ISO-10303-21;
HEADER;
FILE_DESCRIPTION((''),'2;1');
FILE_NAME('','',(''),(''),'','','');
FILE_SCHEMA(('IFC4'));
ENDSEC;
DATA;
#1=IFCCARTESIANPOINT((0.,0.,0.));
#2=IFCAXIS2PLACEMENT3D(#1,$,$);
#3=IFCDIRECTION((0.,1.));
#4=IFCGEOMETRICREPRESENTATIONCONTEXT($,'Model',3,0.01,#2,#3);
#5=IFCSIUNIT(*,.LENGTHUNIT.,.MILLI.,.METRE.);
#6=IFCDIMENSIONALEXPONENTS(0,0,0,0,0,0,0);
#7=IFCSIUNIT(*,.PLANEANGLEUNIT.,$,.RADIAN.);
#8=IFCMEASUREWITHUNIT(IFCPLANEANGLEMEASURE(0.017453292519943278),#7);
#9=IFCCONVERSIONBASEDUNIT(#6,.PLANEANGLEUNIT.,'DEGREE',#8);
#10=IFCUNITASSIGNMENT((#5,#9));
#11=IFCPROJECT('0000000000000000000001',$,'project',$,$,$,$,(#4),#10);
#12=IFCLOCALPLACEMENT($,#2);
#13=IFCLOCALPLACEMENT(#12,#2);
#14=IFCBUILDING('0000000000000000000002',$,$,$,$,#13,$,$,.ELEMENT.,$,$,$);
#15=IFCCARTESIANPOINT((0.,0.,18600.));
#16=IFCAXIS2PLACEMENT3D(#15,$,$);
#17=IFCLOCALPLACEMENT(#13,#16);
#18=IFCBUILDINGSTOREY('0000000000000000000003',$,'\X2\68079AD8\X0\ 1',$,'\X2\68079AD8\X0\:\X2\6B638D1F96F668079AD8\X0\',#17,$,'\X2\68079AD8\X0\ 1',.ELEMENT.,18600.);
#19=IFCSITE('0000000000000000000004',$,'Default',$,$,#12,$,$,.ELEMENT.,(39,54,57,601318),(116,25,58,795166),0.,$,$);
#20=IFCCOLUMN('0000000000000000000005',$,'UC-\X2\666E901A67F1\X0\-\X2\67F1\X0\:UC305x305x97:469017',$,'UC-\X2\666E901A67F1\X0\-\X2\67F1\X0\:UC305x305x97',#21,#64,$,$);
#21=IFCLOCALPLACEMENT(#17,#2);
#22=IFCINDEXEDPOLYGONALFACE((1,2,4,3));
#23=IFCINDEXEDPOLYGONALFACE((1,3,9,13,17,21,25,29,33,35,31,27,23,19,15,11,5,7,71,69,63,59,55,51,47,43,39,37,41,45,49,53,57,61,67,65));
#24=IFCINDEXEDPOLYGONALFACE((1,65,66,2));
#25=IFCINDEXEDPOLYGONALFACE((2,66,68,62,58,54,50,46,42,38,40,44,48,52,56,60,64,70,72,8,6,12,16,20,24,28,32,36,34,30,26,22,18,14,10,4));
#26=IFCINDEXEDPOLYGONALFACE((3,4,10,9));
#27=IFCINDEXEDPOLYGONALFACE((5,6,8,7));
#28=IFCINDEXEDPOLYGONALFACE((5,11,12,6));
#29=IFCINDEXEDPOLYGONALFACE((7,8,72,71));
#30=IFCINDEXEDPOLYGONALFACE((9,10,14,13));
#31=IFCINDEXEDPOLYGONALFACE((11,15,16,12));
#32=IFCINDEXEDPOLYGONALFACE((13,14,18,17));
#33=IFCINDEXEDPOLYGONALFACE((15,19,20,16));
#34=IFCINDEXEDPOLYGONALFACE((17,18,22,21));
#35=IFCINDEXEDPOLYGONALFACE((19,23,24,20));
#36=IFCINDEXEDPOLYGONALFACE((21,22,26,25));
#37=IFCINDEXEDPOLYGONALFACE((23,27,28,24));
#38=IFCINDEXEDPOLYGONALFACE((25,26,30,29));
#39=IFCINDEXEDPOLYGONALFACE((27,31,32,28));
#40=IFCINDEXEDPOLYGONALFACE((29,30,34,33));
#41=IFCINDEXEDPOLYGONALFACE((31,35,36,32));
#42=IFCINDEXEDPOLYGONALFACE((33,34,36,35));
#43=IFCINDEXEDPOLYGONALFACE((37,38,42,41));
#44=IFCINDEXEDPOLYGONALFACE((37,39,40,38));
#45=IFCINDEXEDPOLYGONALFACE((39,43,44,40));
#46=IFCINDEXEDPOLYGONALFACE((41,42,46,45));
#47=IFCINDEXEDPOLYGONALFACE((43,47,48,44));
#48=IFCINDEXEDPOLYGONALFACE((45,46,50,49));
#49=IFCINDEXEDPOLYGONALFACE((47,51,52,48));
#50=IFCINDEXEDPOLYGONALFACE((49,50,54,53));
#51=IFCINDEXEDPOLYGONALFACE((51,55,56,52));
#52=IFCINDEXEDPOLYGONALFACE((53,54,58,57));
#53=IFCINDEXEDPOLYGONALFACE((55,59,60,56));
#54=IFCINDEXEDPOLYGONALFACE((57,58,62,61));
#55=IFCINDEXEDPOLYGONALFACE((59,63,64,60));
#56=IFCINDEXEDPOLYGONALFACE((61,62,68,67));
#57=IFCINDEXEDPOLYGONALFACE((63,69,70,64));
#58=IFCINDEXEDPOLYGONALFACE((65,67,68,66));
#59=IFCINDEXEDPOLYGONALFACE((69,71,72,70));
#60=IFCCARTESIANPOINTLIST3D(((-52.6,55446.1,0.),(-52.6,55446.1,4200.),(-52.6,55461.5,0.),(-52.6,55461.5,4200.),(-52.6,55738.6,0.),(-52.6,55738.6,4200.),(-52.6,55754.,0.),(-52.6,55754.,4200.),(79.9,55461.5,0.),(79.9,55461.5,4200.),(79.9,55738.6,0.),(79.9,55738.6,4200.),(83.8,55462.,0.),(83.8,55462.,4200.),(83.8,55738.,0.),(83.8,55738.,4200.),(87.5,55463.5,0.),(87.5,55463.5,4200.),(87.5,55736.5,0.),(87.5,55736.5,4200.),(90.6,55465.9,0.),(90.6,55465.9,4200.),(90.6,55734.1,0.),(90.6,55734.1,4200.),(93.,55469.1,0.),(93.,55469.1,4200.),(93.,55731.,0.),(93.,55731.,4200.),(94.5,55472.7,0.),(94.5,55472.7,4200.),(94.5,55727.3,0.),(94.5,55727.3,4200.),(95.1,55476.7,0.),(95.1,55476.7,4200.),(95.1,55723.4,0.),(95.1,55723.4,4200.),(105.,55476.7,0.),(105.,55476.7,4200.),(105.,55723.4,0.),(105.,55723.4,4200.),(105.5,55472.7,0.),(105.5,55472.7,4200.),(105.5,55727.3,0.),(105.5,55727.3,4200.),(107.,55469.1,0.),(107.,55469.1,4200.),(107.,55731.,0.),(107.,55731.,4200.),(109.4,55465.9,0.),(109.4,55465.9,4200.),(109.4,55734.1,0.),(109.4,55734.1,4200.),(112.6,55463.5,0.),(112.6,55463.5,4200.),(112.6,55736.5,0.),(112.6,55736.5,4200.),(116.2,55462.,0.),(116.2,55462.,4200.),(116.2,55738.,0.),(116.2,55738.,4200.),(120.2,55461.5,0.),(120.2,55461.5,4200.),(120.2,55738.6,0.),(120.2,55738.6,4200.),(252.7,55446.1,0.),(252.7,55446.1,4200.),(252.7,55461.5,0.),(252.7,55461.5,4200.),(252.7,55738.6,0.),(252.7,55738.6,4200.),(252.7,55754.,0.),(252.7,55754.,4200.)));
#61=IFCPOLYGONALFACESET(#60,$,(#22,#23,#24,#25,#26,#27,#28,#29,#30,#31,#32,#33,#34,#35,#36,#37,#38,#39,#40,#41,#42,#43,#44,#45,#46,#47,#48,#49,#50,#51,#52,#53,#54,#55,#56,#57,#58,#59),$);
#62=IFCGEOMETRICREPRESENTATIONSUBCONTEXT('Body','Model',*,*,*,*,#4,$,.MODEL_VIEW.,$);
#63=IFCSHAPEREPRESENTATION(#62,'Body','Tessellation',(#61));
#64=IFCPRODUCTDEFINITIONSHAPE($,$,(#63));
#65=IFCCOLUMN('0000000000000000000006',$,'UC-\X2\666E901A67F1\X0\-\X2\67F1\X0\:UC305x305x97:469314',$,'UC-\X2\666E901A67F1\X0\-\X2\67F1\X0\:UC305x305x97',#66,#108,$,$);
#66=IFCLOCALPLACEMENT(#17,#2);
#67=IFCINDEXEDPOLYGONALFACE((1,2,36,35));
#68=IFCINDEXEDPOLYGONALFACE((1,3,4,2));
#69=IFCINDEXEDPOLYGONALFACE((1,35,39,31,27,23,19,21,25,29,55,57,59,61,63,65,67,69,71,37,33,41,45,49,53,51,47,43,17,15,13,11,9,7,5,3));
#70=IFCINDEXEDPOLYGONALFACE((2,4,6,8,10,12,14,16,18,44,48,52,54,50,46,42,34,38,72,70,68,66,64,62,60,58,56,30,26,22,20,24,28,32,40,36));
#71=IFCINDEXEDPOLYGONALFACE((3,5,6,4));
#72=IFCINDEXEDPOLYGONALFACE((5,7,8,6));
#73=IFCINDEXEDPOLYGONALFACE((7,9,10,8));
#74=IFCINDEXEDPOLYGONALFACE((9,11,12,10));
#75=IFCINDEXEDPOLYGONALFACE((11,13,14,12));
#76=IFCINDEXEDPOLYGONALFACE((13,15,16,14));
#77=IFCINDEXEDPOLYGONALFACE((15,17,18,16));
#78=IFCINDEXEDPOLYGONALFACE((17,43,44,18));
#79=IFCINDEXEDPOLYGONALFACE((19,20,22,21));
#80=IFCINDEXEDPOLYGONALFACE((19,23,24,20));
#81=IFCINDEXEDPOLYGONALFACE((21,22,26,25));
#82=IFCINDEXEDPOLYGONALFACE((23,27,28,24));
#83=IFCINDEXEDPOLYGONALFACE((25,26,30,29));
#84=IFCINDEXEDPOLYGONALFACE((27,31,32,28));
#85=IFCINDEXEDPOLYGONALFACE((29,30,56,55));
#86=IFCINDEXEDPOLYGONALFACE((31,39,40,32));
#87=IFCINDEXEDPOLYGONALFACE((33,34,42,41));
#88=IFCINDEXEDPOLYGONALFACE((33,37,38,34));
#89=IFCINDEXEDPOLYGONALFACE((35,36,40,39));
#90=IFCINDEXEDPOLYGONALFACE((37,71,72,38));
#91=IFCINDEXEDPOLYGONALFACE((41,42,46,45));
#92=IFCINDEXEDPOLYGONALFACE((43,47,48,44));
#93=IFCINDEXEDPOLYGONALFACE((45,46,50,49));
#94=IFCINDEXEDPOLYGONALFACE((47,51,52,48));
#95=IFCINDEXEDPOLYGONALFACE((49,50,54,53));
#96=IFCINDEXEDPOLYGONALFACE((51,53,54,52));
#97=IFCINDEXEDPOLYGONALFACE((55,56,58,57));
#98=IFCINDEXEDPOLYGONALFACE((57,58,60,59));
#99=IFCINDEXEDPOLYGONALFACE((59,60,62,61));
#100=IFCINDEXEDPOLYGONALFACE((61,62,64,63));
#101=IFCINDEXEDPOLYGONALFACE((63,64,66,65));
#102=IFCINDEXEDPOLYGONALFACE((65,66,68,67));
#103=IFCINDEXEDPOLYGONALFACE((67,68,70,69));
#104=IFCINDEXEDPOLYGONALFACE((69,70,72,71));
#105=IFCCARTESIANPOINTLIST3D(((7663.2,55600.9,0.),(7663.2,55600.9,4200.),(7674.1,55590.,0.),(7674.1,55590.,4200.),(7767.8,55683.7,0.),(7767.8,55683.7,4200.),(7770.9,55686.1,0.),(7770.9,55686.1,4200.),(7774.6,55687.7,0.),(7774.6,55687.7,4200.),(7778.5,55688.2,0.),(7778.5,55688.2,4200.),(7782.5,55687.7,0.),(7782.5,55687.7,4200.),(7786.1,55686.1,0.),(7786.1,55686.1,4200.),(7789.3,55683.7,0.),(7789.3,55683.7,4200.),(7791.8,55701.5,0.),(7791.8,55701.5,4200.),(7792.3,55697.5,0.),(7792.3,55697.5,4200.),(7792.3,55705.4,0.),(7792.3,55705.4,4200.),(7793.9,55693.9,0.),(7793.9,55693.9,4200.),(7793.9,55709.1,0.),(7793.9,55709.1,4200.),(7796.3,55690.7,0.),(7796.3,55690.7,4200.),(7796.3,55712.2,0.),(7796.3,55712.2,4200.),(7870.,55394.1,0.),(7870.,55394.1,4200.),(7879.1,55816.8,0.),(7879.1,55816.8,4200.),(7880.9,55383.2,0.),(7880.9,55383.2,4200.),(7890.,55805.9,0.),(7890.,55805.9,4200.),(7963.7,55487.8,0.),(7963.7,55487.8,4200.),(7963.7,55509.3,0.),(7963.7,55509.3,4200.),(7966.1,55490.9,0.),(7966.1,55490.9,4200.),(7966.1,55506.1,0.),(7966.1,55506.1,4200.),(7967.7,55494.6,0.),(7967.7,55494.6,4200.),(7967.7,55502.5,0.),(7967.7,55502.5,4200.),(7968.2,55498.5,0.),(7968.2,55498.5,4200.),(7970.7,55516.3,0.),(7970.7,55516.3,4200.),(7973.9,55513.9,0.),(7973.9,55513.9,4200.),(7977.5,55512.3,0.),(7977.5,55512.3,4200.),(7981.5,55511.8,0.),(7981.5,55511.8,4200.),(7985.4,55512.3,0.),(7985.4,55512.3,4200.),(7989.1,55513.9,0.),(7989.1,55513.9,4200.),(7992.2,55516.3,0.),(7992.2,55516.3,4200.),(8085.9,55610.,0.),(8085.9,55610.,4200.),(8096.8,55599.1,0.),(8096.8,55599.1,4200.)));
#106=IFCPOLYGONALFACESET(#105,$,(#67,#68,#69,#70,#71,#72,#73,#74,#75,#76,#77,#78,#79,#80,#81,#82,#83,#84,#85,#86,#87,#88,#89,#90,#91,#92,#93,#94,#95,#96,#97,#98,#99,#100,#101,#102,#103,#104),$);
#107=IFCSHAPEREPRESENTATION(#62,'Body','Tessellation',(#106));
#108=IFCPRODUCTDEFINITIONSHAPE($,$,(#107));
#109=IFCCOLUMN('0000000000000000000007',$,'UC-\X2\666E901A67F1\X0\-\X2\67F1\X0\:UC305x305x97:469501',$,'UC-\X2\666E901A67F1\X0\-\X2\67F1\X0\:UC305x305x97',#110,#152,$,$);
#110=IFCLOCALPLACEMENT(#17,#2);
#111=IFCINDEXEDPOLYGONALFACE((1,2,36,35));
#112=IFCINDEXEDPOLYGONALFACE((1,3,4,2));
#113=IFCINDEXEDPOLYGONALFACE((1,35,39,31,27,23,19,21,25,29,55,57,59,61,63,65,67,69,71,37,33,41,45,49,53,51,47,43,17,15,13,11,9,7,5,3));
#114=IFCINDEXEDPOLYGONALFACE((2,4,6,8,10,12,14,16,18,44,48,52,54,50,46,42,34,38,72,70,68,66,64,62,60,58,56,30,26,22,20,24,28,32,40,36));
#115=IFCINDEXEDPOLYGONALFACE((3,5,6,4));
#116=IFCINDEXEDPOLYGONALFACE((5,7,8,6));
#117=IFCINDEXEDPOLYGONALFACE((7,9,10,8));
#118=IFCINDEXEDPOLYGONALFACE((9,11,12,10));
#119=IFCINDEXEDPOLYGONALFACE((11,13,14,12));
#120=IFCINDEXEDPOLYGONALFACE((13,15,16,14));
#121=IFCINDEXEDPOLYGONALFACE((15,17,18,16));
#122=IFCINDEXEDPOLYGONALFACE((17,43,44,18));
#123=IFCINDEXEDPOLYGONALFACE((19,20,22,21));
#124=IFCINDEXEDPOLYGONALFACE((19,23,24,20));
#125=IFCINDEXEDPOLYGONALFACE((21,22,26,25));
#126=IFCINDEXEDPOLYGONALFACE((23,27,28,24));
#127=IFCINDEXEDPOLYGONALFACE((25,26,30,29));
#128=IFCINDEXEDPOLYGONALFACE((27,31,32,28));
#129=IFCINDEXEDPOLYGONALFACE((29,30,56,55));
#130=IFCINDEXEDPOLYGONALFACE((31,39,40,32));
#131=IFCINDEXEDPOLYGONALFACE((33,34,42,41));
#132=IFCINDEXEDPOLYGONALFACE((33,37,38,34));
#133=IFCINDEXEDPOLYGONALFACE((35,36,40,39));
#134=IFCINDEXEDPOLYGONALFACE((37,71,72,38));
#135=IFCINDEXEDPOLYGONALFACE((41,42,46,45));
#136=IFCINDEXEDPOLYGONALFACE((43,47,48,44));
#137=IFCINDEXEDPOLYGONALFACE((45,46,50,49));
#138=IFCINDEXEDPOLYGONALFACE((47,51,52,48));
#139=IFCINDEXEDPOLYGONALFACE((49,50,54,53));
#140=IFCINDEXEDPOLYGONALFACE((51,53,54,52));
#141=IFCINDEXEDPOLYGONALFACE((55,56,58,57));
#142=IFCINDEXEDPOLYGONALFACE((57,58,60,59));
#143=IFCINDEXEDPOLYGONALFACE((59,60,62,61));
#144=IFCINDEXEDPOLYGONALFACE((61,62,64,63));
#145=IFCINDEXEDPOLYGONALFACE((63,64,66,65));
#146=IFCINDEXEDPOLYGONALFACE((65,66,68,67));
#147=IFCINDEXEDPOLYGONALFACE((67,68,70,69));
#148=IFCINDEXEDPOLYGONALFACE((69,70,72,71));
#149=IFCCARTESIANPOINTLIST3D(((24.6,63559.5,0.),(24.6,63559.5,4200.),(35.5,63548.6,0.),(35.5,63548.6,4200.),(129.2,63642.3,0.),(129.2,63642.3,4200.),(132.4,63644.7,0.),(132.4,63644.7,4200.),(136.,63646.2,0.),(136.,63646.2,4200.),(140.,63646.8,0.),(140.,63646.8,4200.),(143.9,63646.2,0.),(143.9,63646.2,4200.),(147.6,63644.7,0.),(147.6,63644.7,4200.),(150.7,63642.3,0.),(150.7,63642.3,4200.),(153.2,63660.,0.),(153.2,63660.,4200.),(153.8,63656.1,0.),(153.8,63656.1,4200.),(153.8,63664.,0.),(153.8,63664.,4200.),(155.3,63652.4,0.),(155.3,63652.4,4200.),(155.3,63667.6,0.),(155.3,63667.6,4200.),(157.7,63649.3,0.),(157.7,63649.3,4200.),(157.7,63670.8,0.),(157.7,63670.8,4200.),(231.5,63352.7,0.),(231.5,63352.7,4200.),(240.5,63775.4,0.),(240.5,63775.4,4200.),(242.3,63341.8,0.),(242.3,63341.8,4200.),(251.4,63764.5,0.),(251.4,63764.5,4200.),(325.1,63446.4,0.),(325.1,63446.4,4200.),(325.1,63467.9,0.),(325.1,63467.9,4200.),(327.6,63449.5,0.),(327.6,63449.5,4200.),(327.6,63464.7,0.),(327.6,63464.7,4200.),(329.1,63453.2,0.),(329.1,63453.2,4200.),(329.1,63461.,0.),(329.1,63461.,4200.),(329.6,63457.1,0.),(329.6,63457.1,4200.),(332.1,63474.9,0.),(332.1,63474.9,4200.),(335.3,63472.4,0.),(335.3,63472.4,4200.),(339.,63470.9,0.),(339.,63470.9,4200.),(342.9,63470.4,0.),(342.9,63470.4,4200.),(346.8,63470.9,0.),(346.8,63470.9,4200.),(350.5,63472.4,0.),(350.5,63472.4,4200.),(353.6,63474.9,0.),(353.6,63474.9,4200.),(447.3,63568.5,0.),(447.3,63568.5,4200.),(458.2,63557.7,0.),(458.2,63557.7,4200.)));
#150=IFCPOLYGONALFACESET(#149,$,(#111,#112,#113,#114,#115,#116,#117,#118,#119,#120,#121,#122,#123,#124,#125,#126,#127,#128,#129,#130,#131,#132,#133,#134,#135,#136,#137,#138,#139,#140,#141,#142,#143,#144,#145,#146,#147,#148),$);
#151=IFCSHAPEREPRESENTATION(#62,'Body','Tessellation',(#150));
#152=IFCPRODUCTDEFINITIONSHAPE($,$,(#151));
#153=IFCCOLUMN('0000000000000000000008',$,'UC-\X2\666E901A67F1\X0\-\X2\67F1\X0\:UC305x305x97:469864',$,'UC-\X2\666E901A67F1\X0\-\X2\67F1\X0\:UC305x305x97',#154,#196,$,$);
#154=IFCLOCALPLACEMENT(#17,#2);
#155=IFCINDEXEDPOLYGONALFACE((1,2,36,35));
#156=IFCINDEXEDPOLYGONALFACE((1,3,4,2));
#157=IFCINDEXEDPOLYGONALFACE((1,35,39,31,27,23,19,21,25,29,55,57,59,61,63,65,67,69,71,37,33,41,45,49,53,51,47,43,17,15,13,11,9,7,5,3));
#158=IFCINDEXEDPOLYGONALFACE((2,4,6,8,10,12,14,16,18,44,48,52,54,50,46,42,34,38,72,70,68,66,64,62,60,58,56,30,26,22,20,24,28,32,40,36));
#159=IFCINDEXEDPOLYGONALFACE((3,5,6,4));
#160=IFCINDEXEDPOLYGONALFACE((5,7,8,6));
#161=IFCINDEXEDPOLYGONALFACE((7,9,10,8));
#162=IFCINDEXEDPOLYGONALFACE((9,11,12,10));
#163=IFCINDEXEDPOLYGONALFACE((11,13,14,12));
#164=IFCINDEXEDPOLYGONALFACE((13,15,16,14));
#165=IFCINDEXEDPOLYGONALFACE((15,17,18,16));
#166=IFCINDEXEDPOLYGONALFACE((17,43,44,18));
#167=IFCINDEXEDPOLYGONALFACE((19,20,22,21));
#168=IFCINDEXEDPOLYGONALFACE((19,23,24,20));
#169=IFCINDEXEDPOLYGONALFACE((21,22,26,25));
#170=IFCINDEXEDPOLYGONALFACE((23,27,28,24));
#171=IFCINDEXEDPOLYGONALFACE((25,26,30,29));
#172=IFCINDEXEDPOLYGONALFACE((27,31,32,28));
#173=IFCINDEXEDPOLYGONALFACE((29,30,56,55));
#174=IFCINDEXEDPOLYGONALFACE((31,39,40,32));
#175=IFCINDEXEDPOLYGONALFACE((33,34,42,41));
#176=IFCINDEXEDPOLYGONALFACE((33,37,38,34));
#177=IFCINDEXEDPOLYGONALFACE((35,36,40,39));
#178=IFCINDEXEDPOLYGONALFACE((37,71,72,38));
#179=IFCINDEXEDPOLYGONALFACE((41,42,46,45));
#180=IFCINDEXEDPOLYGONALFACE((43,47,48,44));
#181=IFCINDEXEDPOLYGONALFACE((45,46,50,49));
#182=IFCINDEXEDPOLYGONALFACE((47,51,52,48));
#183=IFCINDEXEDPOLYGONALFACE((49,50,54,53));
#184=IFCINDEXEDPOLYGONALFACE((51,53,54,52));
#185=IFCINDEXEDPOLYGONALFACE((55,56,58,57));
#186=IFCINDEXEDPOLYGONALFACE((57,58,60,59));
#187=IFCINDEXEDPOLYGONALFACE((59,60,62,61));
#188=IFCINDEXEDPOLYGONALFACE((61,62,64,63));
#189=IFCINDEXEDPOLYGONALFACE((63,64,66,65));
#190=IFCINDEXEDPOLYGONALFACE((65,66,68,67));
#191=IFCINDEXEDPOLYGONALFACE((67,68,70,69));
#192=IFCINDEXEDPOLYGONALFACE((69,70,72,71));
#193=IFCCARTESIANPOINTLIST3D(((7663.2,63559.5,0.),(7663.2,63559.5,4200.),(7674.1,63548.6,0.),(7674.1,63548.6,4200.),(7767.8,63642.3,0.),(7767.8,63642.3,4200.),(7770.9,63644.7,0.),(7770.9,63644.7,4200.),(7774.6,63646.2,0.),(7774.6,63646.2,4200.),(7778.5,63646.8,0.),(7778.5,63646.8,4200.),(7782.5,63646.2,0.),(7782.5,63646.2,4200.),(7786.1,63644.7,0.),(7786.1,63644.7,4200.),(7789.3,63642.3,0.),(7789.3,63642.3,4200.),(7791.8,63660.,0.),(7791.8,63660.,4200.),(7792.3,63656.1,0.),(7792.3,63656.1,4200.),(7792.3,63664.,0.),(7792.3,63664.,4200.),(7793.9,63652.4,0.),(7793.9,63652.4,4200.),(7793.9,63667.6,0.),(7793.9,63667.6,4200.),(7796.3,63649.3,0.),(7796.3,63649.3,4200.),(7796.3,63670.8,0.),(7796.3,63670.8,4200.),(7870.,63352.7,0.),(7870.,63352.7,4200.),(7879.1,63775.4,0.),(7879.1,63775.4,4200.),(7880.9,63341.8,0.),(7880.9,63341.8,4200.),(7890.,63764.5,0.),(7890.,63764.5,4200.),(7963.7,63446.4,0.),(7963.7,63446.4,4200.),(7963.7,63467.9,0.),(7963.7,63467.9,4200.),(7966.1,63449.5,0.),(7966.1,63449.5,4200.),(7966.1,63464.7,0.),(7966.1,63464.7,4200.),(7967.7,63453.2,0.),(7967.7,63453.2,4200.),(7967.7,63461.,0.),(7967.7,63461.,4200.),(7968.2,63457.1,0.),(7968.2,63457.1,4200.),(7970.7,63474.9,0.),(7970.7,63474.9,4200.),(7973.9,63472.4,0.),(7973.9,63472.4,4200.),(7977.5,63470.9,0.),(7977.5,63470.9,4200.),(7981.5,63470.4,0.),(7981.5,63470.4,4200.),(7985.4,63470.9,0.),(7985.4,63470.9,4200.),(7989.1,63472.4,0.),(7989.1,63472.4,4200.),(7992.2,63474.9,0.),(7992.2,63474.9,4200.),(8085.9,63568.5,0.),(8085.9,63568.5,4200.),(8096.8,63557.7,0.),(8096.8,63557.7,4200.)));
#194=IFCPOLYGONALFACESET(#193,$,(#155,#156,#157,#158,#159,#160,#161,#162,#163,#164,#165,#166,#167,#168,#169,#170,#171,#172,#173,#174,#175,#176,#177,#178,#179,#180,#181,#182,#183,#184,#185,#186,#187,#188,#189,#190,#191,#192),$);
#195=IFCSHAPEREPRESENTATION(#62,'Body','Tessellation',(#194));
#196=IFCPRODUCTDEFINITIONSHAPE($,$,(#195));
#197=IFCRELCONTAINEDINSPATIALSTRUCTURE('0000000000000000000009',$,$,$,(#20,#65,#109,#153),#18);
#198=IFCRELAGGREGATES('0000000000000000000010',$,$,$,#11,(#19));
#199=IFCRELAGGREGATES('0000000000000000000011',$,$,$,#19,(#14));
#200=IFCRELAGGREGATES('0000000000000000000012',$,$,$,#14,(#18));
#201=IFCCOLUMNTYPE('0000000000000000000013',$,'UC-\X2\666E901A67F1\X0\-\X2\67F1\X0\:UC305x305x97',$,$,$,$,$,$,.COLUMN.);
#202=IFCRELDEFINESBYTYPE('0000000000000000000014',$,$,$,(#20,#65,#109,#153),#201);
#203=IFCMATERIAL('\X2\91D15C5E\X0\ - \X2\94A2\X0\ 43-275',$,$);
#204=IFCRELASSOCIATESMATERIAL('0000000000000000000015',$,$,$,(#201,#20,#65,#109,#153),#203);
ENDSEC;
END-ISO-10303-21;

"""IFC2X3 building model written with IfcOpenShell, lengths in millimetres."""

from ifc_helpers import new_model, entity, si_unit, converted_unit, direction, frame, origin, origin_2d_with_axis, place, context, subcontext, project, spatial, i_section, extrude, source, transform, mapped, material, type_object, type_shapes, element, save


model = new_model("IFC2X3")

# Units and contexts
model_context = context("Model", 3, precision=0.01, world=origin(), true_north=direction((0.0, 1.0)))
body_context = subcontext(model_context, "Body", "Model", "MODEL_VIEW")
ifc_project = project(units=[si_unit("LENGTHUNIT", "METRE", prefix="MILLI"), converted_unit("PLANEANGLEUNIT", "DEGREE", entity("IfcPlaneAngleMeasure", 0.017453292519943278), si_unit("PLANEANGLEUNIT", "RADIAN"), dimensions=[0, 0, 0, 0, 0, 0, 0])], contexts=[model_context])

# Site, building, storey
site_placement = place(None, origin())
site = spatial("IfcSite", under=ifc_project, at=site_placement, Name="Default", CompositionType="ELEMENT", RefLatitude=(39, 54, 57, 601318), RefLongitude=(116, 25, 58, 795166), RefElevation=0.0)
building_placement = place(site_placement, origin())
building = spatial("IfcBuilding", under=site, at=building_placement, CompositionType="ELEMENT")
storey_placement = place(building_placement, frame((0.0, 0.0, 18600.0)))
storey = spatial("IfcBuildingStorey", under=building, at=storey_placement, Name="标高 1", ObjectType="标高:正负零标高", LongName="标高 1", CompositionType="ELEMENT", Elevation=18600.0)

# Columns
ifc_material_1 = material(Name="金属 - 钢 43-275")
column_type = type_object("IfcColumnType", Name="UC-普通柱-柱:UC305x305x97", PredefinedType="COLUMN", material=ifc_material_1)
shared_shape_1 = source(origin(), body_context, "Body", "SweptSolid", [
    extrude(i_section(OverallWidth=305.3, OverallDepth=307.9, WebThickness=9.9, FlangeThickness=15.4, FilletRadius=15.2, at=origin_2d_with_axis()), frame((0.0, 0.0, 18600.0), z_axis=(0.0, 0.0, 1.0), x_axis=(-1.0, 0.0, 0.0)), (0.0, 0.0, 1.0), 4200.0),
])
type_shapes(column_type, [shared_shape_1])
column_placement = place(storey_placement, frame((100.0, 55600.0, -18600.0)))
element("IfcColumn", 1, at=column_placement, inside=storey, type_object=column_type, material=ifc_material_1, Name="UC-普通柱-柱:UC305x305x97:469017", ObjectType="UC-普通柱-柱:UC305x305x97", context=body_context, shape_type="MappedRepresentation", body=[
    mapped(shared_shape_1, transform((0.0, 0.0, 0.0), scale=1.0)),
])
for number, where, z_axis, x_axis, name in (
    (2, (7880.0, 55600.0, -18600.0), (0.0, 0.0, 1.0), (0.707107, 0.707107, 0.0), "UC-普通柱-柱:UC305x305x97:469314"),
    (3, (241.4, 63558.6, -18600.0), (0.0, 0.0, 1.0), (0.707107, 0.707107, 0.0), "UC-普通柱-柱:UC305x305x97:469501"),
    (4, (7880.0, 63558.6, -18600.0), (0.0, 0.0, 1.0), (0.707107, 0.707107, 0.0), "UC-普通柱-柱:UC305x305x97:469864"),
):
    element("IfcColumn", number, at=place(storey_placement, frame(where, z_axis=z_axis, x_axis=x_axis)), inside=storey, type_object=column_type, material=ifc_material_1, Name=name, ObjectType="UC-普通柱-柱:UC305x305x97", context=body_context, shape_type="MappedRepresentation", body=[
        mapped(shared_shape_1, transform((0.0, 0.0, 0.0), scale=1.0)),
    ])

save(model, "model.ifc")
